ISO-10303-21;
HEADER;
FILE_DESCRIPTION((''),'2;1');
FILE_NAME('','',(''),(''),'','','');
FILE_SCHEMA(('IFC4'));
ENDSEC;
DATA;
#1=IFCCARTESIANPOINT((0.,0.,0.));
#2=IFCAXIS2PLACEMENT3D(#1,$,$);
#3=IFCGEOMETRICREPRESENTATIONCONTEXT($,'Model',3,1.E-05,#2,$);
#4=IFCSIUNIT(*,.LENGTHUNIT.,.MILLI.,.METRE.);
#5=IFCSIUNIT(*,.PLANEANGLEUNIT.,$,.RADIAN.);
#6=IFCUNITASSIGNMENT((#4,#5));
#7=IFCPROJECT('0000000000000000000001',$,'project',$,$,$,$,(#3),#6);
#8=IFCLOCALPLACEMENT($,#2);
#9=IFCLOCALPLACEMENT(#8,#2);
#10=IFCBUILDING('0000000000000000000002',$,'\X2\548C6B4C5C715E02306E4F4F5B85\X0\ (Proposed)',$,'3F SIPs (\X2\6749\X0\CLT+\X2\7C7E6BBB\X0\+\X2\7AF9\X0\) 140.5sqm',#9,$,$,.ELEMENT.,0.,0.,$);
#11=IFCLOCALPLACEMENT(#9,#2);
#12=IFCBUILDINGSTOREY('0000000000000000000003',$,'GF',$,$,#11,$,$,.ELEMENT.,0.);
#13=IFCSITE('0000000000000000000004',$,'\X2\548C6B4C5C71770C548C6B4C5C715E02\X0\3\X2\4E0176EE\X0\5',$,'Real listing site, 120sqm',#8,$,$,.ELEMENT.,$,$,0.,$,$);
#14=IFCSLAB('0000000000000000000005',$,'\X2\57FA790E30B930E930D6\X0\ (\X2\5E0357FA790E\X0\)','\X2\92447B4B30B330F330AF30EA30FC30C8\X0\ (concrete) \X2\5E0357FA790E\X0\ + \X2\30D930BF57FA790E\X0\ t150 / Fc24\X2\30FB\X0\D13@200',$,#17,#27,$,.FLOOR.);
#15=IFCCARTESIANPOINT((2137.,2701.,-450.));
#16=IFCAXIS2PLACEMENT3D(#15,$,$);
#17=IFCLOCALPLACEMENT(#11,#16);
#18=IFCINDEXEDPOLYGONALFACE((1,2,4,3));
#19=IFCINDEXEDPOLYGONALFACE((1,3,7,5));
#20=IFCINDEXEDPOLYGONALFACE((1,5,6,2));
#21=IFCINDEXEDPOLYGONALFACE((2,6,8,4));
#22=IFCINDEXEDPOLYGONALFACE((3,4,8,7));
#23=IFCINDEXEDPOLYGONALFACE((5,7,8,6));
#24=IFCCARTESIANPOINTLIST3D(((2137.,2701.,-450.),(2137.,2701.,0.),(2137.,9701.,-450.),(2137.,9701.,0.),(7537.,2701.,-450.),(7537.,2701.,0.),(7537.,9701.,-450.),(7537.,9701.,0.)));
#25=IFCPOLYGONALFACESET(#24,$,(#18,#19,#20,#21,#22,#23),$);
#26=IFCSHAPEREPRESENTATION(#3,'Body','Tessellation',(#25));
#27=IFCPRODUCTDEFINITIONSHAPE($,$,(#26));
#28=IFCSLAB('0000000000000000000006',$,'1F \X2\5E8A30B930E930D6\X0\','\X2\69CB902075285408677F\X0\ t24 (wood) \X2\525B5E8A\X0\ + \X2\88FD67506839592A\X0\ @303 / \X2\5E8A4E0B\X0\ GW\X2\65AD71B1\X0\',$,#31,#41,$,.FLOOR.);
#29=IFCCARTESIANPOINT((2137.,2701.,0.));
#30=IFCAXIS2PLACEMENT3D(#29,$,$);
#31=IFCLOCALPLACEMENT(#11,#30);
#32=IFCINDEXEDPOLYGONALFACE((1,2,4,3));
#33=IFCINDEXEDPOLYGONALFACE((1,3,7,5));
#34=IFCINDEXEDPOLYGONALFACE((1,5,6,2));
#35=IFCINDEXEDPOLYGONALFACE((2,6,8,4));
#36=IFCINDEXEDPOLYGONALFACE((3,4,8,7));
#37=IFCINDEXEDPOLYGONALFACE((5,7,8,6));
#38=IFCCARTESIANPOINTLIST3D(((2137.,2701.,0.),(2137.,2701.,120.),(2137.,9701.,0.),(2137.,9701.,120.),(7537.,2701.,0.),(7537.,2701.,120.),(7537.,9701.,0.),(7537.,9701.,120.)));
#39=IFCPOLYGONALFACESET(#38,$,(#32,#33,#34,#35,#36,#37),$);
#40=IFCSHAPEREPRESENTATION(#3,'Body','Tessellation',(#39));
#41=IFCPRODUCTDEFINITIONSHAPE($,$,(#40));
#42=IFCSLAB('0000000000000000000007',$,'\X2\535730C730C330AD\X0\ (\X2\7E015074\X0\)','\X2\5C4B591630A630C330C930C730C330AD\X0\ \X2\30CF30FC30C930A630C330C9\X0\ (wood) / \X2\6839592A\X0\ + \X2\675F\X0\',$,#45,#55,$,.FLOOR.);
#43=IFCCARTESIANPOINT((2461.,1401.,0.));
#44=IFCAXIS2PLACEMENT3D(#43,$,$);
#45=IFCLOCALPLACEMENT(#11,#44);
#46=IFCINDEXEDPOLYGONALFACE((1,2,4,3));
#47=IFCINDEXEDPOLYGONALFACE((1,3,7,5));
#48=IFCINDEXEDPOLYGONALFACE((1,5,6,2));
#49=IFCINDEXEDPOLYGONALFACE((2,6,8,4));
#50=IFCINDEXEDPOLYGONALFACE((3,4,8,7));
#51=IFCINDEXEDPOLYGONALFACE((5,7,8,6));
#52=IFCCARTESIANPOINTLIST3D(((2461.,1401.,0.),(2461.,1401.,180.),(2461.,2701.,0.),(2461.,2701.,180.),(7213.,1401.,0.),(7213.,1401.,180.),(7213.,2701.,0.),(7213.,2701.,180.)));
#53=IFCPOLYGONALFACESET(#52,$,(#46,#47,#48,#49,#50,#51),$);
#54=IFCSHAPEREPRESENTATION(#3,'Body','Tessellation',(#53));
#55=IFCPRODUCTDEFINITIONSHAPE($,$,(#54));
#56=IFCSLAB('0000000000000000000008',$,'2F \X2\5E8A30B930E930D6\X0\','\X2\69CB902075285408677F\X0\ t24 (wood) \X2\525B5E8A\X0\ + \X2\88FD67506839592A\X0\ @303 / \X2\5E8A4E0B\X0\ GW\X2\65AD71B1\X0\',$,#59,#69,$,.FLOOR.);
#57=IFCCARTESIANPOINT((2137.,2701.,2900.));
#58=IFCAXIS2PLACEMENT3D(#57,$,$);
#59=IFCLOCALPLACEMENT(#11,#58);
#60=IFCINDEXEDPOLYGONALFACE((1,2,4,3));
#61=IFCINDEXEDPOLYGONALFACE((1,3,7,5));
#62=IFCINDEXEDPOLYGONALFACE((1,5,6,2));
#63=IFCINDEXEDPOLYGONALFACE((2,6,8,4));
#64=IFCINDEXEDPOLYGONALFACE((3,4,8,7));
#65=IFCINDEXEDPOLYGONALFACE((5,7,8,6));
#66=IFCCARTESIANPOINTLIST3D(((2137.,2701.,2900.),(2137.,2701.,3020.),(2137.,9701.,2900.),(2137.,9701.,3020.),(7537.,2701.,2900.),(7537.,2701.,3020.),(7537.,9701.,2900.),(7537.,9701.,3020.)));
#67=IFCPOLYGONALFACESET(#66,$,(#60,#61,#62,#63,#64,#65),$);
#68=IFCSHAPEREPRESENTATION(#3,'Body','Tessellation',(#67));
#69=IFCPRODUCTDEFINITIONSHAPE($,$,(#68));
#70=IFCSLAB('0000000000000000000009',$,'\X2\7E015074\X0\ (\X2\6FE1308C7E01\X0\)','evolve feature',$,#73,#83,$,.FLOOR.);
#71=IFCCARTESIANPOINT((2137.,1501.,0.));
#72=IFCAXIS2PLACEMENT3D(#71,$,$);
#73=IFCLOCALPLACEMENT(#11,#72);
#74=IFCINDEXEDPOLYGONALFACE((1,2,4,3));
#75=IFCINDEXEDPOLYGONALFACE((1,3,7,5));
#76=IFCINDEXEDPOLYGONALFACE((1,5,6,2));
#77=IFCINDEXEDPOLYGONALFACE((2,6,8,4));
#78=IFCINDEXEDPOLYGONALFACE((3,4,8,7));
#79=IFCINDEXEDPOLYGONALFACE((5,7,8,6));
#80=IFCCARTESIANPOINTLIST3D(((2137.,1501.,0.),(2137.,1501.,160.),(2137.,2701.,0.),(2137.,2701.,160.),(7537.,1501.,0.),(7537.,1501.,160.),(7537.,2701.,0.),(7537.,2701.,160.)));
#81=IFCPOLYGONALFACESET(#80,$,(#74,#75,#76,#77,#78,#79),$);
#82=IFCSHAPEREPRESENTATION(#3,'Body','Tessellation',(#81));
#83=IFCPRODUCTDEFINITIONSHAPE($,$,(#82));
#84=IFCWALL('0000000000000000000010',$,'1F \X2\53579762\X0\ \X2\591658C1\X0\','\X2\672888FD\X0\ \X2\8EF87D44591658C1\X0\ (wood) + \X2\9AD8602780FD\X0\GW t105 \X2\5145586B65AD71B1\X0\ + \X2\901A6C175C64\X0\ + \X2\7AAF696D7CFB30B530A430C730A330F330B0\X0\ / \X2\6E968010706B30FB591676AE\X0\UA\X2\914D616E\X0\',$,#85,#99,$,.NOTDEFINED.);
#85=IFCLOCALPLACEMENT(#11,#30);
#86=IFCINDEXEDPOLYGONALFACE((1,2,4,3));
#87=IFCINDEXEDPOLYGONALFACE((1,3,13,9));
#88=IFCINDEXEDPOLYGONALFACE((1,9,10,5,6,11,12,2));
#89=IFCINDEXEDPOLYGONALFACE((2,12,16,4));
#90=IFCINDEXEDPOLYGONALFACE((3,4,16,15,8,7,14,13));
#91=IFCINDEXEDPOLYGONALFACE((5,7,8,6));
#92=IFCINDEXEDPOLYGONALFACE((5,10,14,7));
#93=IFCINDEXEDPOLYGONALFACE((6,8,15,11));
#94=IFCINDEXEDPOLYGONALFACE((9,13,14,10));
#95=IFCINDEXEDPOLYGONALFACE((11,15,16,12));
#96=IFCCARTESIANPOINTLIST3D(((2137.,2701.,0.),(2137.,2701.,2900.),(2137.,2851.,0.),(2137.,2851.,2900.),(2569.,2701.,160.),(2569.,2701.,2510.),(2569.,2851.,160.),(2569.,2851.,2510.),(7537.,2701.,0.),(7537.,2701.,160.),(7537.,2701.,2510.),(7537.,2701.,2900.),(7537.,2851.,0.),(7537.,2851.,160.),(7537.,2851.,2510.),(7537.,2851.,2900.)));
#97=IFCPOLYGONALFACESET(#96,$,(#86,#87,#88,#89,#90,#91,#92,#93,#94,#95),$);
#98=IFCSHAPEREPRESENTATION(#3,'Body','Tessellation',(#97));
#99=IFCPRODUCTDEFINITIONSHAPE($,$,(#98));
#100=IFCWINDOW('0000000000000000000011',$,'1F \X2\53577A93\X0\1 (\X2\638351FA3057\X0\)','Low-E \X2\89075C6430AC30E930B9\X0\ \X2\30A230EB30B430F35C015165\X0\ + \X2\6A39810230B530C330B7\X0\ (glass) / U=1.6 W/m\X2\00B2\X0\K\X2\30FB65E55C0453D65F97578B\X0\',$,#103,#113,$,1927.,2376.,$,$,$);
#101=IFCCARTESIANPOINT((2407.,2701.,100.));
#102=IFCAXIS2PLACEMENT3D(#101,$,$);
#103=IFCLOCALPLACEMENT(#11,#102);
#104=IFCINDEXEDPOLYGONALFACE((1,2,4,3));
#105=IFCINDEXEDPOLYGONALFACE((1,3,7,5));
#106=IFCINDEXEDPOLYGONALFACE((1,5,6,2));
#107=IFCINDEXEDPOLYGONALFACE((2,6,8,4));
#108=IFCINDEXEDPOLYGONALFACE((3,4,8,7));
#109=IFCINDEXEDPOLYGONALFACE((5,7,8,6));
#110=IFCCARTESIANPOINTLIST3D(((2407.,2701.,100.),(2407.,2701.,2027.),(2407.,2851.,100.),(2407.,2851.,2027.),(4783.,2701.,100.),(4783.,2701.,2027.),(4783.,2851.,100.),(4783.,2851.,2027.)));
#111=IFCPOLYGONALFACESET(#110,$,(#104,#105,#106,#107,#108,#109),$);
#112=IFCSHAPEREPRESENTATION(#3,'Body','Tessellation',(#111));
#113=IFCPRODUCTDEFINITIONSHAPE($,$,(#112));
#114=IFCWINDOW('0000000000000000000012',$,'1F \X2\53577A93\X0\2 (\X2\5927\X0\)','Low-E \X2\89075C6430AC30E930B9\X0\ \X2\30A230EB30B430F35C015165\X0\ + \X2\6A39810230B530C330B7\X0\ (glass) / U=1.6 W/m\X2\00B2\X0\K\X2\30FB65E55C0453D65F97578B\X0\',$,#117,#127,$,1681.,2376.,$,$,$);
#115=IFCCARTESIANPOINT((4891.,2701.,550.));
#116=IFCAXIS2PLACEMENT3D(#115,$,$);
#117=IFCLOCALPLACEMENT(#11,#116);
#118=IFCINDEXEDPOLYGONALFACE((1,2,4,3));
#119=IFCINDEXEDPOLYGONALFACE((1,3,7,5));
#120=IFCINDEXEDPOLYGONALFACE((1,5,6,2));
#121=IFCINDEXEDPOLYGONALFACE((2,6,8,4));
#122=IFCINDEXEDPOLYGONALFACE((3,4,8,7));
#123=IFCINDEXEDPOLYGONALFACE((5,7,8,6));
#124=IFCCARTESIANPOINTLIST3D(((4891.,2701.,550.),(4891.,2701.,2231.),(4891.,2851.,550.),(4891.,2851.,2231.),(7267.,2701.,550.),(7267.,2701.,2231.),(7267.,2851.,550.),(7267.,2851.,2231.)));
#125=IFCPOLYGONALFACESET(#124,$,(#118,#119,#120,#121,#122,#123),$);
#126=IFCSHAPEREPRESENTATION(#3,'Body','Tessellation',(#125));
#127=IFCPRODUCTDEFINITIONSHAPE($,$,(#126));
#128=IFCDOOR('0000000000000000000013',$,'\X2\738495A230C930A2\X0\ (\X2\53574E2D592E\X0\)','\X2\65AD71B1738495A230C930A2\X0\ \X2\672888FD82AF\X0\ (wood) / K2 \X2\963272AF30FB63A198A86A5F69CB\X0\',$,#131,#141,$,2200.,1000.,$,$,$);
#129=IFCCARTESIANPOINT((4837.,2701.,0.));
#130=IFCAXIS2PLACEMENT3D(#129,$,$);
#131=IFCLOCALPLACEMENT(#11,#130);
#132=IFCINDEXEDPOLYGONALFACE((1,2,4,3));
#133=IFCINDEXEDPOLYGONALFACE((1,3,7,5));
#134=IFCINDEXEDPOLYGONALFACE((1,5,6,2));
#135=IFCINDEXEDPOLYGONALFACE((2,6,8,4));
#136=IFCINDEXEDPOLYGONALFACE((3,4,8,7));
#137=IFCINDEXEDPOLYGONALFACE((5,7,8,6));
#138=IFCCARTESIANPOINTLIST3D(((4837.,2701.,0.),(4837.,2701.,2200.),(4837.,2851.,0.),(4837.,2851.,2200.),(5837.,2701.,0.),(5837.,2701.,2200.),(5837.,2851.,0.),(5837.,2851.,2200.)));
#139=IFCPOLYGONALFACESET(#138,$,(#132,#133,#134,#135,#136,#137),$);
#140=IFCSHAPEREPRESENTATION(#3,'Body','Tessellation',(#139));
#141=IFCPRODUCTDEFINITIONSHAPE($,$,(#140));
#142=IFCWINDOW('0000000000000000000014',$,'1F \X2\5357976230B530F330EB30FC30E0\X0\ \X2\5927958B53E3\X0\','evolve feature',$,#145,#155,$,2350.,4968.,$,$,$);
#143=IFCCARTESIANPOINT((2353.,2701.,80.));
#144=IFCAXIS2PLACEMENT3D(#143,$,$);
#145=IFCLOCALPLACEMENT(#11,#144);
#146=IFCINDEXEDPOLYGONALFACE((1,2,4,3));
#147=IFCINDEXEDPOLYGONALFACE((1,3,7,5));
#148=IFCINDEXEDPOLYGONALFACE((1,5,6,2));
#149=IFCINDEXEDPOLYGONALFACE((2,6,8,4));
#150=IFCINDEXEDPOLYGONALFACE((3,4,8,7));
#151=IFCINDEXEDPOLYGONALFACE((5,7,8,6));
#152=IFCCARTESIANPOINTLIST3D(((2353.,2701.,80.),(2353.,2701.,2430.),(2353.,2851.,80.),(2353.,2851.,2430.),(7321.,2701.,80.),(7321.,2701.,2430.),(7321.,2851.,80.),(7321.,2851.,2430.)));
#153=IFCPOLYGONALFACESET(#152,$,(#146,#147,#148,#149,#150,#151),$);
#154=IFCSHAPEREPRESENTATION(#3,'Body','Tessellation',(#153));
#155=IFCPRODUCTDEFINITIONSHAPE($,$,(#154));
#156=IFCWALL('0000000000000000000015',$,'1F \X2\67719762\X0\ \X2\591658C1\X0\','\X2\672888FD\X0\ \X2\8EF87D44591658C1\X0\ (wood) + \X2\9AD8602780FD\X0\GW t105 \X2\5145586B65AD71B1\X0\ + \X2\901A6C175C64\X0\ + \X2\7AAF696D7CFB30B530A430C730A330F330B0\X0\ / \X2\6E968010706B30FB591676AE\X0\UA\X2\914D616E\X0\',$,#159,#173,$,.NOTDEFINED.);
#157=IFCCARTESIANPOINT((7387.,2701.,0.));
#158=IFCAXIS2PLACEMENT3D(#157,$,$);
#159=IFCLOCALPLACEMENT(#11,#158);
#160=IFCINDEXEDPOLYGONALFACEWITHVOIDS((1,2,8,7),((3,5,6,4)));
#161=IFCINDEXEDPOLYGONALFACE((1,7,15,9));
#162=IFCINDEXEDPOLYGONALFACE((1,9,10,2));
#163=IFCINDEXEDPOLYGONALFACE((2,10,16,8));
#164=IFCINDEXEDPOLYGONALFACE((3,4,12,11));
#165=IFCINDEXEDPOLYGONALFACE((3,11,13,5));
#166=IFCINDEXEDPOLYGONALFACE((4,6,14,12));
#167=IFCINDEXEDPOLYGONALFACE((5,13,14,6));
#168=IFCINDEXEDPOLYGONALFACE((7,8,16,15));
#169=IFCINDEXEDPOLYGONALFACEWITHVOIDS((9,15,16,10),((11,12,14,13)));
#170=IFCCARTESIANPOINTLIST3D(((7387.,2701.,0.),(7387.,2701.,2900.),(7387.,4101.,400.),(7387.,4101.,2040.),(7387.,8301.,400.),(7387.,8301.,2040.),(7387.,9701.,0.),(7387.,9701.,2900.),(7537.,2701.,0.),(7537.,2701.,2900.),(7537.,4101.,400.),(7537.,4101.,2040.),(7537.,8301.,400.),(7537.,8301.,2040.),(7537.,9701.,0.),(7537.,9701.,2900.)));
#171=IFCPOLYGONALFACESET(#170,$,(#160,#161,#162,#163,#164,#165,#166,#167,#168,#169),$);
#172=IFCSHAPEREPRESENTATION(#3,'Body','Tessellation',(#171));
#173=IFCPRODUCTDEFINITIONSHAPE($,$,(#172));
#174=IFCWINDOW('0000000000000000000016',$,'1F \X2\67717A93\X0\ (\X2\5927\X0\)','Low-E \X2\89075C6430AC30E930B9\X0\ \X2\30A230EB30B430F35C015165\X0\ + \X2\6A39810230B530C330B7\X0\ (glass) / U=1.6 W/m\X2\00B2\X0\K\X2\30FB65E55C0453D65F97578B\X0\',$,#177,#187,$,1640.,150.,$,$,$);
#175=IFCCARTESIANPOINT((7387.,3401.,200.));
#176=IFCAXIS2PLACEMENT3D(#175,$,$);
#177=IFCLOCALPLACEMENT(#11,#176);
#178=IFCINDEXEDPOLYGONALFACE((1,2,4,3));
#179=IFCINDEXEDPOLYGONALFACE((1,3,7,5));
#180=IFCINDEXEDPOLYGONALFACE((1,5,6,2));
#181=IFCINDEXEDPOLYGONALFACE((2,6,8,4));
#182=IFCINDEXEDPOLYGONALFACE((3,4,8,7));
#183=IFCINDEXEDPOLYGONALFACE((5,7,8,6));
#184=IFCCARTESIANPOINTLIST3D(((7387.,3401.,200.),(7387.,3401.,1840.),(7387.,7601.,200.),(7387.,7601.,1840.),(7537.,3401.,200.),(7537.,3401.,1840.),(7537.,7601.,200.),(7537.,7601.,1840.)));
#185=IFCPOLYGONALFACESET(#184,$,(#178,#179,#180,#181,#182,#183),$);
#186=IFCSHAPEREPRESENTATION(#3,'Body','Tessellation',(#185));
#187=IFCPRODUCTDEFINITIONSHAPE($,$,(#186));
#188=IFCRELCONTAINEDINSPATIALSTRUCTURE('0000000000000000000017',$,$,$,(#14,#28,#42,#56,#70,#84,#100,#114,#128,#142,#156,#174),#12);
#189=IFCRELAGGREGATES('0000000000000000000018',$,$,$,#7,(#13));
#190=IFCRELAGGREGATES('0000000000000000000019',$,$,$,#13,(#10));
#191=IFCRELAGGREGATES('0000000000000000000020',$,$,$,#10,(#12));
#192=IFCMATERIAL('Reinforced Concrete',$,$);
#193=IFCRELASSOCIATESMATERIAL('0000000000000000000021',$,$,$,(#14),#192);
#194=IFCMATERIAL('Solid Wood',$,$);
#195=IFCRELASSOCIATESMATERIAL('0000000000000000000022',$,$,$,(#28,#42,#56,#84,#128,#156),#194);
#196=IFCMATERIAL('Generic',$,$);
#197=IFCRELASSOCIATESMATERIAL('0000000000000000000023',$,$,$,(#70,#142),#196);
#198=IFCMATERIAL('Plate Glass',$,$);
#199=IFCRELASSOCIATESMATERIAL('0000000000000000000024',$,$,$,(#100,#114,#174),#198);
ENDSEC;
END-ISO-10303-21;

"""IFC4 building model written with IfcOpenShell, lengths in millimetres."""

from ifc_helpers import new_model, si_unit, frame, frame_2d, origin, place, context, project, spatial, rectangle, extrude, material, element, fill, save


model = new_model("IFC4")

# Units and contexts
model_context = context("Model", 3, precision=1e-05, world=origin())
ifc_project = project(units=[si_unit("LENGTHUNIT", "METRE", prefix="MILLI"), si_unit("PLANEANGLEUNIT", "RADIAN")], contexts=[model_context])

# Site, building, storey
site_placement = place(None, origin())
site = spatial("IfcSite", under=ifc_project, at=site_placement, Name="和歌山県和歌山市3丁目5", ObjectType="Real listing site, 120sqm", CompositionType="ELEMENT", RefElevation=0.0)
building_placement = place(site_placement, origin())
building = spatial("IfcBuilding", under=site, at=building_placement, Name="和歌山市の住宅 (Proposed)", ObjectType="3F SIPs (杉CLT+籾殻+竹) 140.5sqm", CompositionType="ELEMENT", ElevationOfRefHeight=0.0, ElevationOfTerrain=0.0)
storey_placement = place(building_placement, origin())
storey = spatial("IfcBuildingStorey", under=building, at=storey_placement, Name="GF", CompositionType="ELEMENT", Elevation=0.0)

# Slabs
ifc_material_1 = material(Name="Reinforced Concrete")
slab_1_placement = place(storey_placement, frame((2137.0, 2701.0, -450.0)))
element("IfcSlab", 1, at=slab_1_placement, inside=storey, material=ifc_material_1, Name="基礎スラブ (布基礎)", Description="鉄筋コンクリート (concrete) 布基礎 + ベタ基礎 t150 / Fc24・D13@200", PredefinedType="FLOOR", context=model_context, shape_type="SweptSolid", body=[
    extrude(rectangle(XDim=5400.0, YDim=7000.0, at=frame_2d((2700.0, 3500.0))), frame((2137.0, 2701.0, -450.0)), (0.0, 0.0, 1.0), 450.0),
])
ifc_material_2 = material(Name="Solid Wood")
slab_2_placement = place(storey_placement, frame((2137.0, 2701.0, 0.0)))
element("IfcSlab", 2, at=slab_2_placement, inside=storey, material=ifc_material_2, Name="1F 床スラブ", Description="構造用合板 t24 (wood) 剛床 + 製材根太 @303 / 床下 GW断熱", PredefinedType="FLOOR", context=model_context, shape_type="SweptSolid", body=[
    extrude(rectangle(XDim=5400.0, YDim=7000.0, at=frame_2d((2700.0, 3500.0))), frame((2137.0, 2701.0, 0.0)), (0.0, 0.0, 1.0), 120.0),
])
slab_3_placement = place(storey_placement, frame((2461.0, 1401.0, 0.0)))
element("IfcSlab", 3, at=slab_3_placement, inside=storey, material=ifc_material_2, Name="南デッキ (縁側)", Description="屋外ウッドデッキ ハードウッド (wood) / 根太 + 束", PredefinedType="FLOOR", context=model_context, shape_type="SweptSolid", body=[
    extrude(rectangle(XDim=4752.0, YDim=1300.0, at=frame_2d((2376.0, 650.0))), frame((2461.0, 1401.0, 0.0)), (0.0, 0.0, 1.0), 180.0),
])
slab_4_placement = place(storey_placement, frame((2137.0, 2701.0, 2900.0)))
element("IfcSlab", 4, at=slab_4_placement, inside=storey, material=ifc_material_2, Name="2F 床スラブ", Description="構造用合板 t24 (wood) 剛床 + 製材根太 @303 / 床下 GW断熱", PredefinedType="FLOOR", context=model_context, shape_type="SweptSolid", body=[
    extrude(rectangle(XDim=5400.0, YDim=7000.0, at=frame_2d((2700.0, 3500.0))), frame((2137.0, 2701.0, 2900.0)), (0.0, 0.0, 1.0), 120.0),
])
ifc_material_3 = material(Name="Generic")
slab_5_placement = place(storey_placement, frame((2137.0, 1501.0, 0.0)))
element("IfcSlab", 5, at=slab_5_placement, inside=storey, material=ifc_material_3, Name="縁側 (濡れ縁)", Description="evolve feature", PredefinedType="FLOOR", context=model_context, shape_type="SweptSolid", body=[
    extrude(rectangle(XDim=5400.0, YDim=1200.0, at=frame_2d((2700.0, 600.0))), frame((2137.0, 1501.0, 0.0)), (0.0, 0.0, 1.0), 160.0),
])

# Wall, openings, windows, door
wall_1_placement = place(storey_placement, frame((2137.0, 2701.0, 0.0)))
wall_1 = element("IfcWall", 6, at=wall_1_placement, inside=storey, material=ifc_material_2, Name="1F 南面 外壁", Description="木製 軸組外壁 (wood) + 高性能GW t105 充填断熱 + 通気層 + 窯業系サイディング / 準耐火・外皮UA配慮", PredefinedType="NOTDEFINED", context=model_context, shape_type="SweptSolid", body=[
    extrude(rectangle(XDim=5400.0, YDim=150.0, at=frame_2d((2700.0, 75.0))), frame((2137.0, 2701.0, 0.0)), (0.0, 0.0, 1.0), 2900.0),
])
opening_1_placement = place(storey_placement, frame((2407.0, 2701.0, 100.0)))
opening_1 = element("IfcOpeningElement", 7, at=opening_1_placement, cuts=wall_1, PredefinedType="NOTDEFINED", context=model_context, shape_type="SweptSolid", body=[
    extrude(rectangle(XDim=2376.0, YDim=150.0, at=frame_2d((1188.0, 75.0))), frame((2407.0, 2701.0, 100.0)), (0.0, 0.0, 1.0), 1927.0),
])
opening_2_placement = place(storey_placement, frame((4891.0, 2701.0, 550.0)))
opening_2 = element("IfcOpeningElement", 8, at=opening_2_placement, cuts=wall_1, PredefinedType="NOTDEFINED", context=model_context, shape_type="SweptSolid", body=[
    extrude(rectangle(XDim=2376.0, YDim=150.0, at=frame_2d((1188.0, 75.0))), frame((4891.0, 2701.0, 550.0)), (0.0, 0.0, 1.0), 1681.0),
])
opening_3_placement = place(storey_placement, frame((4837.0, 2701.0, 0.0)))
opening_3 = element("IfcOpeningElement", 9, at=opening_3_placement, cuts=wall_1, PredefinedType="NOTDEFINED", context=model_context, shape_type="SweptSolid", body=[
    extrude(rectangle(XDim=1000.0, YDim=150.0, at=frame_2d((500.0, 75.0))), frame((4837.0, 2701.0, 0.0)), (0.0, 0.0, 1.0), 2200.0),
])
opening_4_placement = place(storey_placement, frame((2353.0, 2701.0, 80.0)))
opening_4 = element("IfcOpeningElement", 10, at=opening_4_placement, cuts=wall_1, PredefinedType="NOTDEFINED", context=model_context, shape_type="SweptSolid", body=[
    extrude(rectangle(XDim=4968.0, YDim=150.0, at=frame_2d((2484.0, 75.0))), frame((2353.0, 2701.0, 80.0)), (0.0, 0.0, 1.0), 2350.0),
])
ifc_material_4 = material(Name="Plate Glass")
window_1_placement = place(storey_placement, frame((2407.0, 2701.0, 100.0)))
window_1 = element("IfcWindow", 11, at=window_1_placement, inside=storey, material=ifc_material_4, Name="1F 南窓1 (掃出し)", Description="Low-E 複層ガラス アルゴン封入 + 樹脂サッシ (glass) / U=1.6 W/m²K・日射取得型", OverallHeight=1927.0, OverallWidth=2376.0, context=model_context, shape_type="SweptSolid", body=[
    extrude(rectangle(XDim=2376.0, YDim=150.0, at=frame_2d((1188.0, 75.0))), frame((2407.0, 2701.0, 100.0)), (0.0, 0.0, 1.0), 1927.0),
])
fill(opening_1, window_1)
window_2_placement = place(storey_placement, frame((4891.0, 2701.0, 550.0)))
window_2 = element("IfcWindow", 12, at=window_2_placement, inside=storey, material=ifc_material_4, Name="1F 南窓2 (大)", Description="Low-E 複層ガラス アルゴン封入 + 樹脂サッシ (glass) / U=1.6 W/m²K・日射取得型", OverallHeight=1681.0, OverallWidth=2376.0, context=model_context, shape_type="SweptSolid", body=[
    extrude(rectangle(XDim=2376.0, YDim=150.0, at=frame_2d((1188.0, 75.0))), frame((4891.0, 2701.0, 550.0)), (0.0, 0.0, 1.0), 1681.0),
])
fill(opening_2, window_2)
door_placement = place(storey_placement, frame((4837.0, 2701.0, 0.0)))
door = element("IfcDoor", 13, at=door_placement, inside=storey, material=ifc_material_2, Name="玄関ドア (南中央)", Description="断熱玄関ドア 木製芯 (wood) / K2 防犯・採風機構", OverallHeight=2200.0, OverallWidth=1000.0, context=model_context, shape_type="SweptSolid", body=[
    extrude(rectangle(XDim=1000.0, YDim=150.0, at=frame_2d((500.0, 75.0))), frame((4837.0, 2701.0, 0.0)), (0.0, 0.0, 1.0), 2200.0),
])
fill(opening_3, door)
window_3_placement = place(storey_placement, frame((2353.0, 2701.0, 80.0)))
window_3 = element("IfcWindow", 14, at=window_3_placement, inside=storey, material=ifc_material_3, Name="1F 南面サンルーム 大開口", Description="evolve feature", OverallHeight=2350.0, OverallWidth=4968.0, context=model_context, shape_type="SweptSolid", body=[
    extrude(rectangle(XDim=4968.0, YDim=150.0, at=frame_2d((2484.0, 75.0))), frame((2353.0, 2701.0, 80.0)), (0.0, 0.0, 1.0), 2350.0),
])
fill(opening_4, window_3)

# Wall, opening, window
wall_2_placement = place(storey_placement, frame((7387.0, 2701.0, 0.0)))
wall_2 = element("IfcWall", 15, at=wall_2_placement, inside=storey, material=ifc_material_2, Name="1F 東面 外壁", Description="木製 軸組外壁 (wood) + 高性能GW t105 充填断熱 + 通気層 + 窯業系サイディング / 準耐火・外皮UA配慮", PredefinedType="NOTDEFINED", context=model_context, shape_type="SweptSolid", body=[
    extrude(rectangle(XDim=150.0, YDim=7000.0, at=frame_2d((75.0, 3500.0))), frame((7387.0, 2701.0, 0.0)), (0.0, 0.0, 1.0), 2900.0),
])
opening_5_placement = place(storey_placement, frame((7387.0, 3401.0, 200.0)))
opening_5 = element("IfcOpeningElement", 16, at=opening_5_placement, cuts=wall_2, PredefinedType="NOTDEFINED", context=model_context, shape_type="SweptSolid", body=[
    extrude(rectangle(XDim=150.0, YDim=4200.0, at=frame_2d((75.0, 2100.0))), frame((7387.0, 3401.0, 200.0)), (0.0, 0.0, 1.0), 1640.0),
])
window_4_placement = place(storey_placement, frame((7387.0, 3401.0, 200.0)))
window_4 = element("IfcWindow", 17, at=window_4_placement, inside=storey, material=ifc_material_4, Name="1F 東窓 (大)", Description="Low-E 複層ガラス アルゴン封入 + 樹脂サッシ (glass) / U=1.6 W/m²K・日射取得型", OverallHeight=1640.0, OverallWidth=150.0, context=model_context, shape_type="SweptSolid", body=[
    extrude(rectangle(XDim=150.0, YDim=4200.0, at=frame_2d((75.0, 2100.0))), frame((7387.0, 3401.0, 200.0)), (0.0, 0.0, 1.0), 1640.0),
])
fill(opening_5, window_4)

save(model, "model.ifc")
